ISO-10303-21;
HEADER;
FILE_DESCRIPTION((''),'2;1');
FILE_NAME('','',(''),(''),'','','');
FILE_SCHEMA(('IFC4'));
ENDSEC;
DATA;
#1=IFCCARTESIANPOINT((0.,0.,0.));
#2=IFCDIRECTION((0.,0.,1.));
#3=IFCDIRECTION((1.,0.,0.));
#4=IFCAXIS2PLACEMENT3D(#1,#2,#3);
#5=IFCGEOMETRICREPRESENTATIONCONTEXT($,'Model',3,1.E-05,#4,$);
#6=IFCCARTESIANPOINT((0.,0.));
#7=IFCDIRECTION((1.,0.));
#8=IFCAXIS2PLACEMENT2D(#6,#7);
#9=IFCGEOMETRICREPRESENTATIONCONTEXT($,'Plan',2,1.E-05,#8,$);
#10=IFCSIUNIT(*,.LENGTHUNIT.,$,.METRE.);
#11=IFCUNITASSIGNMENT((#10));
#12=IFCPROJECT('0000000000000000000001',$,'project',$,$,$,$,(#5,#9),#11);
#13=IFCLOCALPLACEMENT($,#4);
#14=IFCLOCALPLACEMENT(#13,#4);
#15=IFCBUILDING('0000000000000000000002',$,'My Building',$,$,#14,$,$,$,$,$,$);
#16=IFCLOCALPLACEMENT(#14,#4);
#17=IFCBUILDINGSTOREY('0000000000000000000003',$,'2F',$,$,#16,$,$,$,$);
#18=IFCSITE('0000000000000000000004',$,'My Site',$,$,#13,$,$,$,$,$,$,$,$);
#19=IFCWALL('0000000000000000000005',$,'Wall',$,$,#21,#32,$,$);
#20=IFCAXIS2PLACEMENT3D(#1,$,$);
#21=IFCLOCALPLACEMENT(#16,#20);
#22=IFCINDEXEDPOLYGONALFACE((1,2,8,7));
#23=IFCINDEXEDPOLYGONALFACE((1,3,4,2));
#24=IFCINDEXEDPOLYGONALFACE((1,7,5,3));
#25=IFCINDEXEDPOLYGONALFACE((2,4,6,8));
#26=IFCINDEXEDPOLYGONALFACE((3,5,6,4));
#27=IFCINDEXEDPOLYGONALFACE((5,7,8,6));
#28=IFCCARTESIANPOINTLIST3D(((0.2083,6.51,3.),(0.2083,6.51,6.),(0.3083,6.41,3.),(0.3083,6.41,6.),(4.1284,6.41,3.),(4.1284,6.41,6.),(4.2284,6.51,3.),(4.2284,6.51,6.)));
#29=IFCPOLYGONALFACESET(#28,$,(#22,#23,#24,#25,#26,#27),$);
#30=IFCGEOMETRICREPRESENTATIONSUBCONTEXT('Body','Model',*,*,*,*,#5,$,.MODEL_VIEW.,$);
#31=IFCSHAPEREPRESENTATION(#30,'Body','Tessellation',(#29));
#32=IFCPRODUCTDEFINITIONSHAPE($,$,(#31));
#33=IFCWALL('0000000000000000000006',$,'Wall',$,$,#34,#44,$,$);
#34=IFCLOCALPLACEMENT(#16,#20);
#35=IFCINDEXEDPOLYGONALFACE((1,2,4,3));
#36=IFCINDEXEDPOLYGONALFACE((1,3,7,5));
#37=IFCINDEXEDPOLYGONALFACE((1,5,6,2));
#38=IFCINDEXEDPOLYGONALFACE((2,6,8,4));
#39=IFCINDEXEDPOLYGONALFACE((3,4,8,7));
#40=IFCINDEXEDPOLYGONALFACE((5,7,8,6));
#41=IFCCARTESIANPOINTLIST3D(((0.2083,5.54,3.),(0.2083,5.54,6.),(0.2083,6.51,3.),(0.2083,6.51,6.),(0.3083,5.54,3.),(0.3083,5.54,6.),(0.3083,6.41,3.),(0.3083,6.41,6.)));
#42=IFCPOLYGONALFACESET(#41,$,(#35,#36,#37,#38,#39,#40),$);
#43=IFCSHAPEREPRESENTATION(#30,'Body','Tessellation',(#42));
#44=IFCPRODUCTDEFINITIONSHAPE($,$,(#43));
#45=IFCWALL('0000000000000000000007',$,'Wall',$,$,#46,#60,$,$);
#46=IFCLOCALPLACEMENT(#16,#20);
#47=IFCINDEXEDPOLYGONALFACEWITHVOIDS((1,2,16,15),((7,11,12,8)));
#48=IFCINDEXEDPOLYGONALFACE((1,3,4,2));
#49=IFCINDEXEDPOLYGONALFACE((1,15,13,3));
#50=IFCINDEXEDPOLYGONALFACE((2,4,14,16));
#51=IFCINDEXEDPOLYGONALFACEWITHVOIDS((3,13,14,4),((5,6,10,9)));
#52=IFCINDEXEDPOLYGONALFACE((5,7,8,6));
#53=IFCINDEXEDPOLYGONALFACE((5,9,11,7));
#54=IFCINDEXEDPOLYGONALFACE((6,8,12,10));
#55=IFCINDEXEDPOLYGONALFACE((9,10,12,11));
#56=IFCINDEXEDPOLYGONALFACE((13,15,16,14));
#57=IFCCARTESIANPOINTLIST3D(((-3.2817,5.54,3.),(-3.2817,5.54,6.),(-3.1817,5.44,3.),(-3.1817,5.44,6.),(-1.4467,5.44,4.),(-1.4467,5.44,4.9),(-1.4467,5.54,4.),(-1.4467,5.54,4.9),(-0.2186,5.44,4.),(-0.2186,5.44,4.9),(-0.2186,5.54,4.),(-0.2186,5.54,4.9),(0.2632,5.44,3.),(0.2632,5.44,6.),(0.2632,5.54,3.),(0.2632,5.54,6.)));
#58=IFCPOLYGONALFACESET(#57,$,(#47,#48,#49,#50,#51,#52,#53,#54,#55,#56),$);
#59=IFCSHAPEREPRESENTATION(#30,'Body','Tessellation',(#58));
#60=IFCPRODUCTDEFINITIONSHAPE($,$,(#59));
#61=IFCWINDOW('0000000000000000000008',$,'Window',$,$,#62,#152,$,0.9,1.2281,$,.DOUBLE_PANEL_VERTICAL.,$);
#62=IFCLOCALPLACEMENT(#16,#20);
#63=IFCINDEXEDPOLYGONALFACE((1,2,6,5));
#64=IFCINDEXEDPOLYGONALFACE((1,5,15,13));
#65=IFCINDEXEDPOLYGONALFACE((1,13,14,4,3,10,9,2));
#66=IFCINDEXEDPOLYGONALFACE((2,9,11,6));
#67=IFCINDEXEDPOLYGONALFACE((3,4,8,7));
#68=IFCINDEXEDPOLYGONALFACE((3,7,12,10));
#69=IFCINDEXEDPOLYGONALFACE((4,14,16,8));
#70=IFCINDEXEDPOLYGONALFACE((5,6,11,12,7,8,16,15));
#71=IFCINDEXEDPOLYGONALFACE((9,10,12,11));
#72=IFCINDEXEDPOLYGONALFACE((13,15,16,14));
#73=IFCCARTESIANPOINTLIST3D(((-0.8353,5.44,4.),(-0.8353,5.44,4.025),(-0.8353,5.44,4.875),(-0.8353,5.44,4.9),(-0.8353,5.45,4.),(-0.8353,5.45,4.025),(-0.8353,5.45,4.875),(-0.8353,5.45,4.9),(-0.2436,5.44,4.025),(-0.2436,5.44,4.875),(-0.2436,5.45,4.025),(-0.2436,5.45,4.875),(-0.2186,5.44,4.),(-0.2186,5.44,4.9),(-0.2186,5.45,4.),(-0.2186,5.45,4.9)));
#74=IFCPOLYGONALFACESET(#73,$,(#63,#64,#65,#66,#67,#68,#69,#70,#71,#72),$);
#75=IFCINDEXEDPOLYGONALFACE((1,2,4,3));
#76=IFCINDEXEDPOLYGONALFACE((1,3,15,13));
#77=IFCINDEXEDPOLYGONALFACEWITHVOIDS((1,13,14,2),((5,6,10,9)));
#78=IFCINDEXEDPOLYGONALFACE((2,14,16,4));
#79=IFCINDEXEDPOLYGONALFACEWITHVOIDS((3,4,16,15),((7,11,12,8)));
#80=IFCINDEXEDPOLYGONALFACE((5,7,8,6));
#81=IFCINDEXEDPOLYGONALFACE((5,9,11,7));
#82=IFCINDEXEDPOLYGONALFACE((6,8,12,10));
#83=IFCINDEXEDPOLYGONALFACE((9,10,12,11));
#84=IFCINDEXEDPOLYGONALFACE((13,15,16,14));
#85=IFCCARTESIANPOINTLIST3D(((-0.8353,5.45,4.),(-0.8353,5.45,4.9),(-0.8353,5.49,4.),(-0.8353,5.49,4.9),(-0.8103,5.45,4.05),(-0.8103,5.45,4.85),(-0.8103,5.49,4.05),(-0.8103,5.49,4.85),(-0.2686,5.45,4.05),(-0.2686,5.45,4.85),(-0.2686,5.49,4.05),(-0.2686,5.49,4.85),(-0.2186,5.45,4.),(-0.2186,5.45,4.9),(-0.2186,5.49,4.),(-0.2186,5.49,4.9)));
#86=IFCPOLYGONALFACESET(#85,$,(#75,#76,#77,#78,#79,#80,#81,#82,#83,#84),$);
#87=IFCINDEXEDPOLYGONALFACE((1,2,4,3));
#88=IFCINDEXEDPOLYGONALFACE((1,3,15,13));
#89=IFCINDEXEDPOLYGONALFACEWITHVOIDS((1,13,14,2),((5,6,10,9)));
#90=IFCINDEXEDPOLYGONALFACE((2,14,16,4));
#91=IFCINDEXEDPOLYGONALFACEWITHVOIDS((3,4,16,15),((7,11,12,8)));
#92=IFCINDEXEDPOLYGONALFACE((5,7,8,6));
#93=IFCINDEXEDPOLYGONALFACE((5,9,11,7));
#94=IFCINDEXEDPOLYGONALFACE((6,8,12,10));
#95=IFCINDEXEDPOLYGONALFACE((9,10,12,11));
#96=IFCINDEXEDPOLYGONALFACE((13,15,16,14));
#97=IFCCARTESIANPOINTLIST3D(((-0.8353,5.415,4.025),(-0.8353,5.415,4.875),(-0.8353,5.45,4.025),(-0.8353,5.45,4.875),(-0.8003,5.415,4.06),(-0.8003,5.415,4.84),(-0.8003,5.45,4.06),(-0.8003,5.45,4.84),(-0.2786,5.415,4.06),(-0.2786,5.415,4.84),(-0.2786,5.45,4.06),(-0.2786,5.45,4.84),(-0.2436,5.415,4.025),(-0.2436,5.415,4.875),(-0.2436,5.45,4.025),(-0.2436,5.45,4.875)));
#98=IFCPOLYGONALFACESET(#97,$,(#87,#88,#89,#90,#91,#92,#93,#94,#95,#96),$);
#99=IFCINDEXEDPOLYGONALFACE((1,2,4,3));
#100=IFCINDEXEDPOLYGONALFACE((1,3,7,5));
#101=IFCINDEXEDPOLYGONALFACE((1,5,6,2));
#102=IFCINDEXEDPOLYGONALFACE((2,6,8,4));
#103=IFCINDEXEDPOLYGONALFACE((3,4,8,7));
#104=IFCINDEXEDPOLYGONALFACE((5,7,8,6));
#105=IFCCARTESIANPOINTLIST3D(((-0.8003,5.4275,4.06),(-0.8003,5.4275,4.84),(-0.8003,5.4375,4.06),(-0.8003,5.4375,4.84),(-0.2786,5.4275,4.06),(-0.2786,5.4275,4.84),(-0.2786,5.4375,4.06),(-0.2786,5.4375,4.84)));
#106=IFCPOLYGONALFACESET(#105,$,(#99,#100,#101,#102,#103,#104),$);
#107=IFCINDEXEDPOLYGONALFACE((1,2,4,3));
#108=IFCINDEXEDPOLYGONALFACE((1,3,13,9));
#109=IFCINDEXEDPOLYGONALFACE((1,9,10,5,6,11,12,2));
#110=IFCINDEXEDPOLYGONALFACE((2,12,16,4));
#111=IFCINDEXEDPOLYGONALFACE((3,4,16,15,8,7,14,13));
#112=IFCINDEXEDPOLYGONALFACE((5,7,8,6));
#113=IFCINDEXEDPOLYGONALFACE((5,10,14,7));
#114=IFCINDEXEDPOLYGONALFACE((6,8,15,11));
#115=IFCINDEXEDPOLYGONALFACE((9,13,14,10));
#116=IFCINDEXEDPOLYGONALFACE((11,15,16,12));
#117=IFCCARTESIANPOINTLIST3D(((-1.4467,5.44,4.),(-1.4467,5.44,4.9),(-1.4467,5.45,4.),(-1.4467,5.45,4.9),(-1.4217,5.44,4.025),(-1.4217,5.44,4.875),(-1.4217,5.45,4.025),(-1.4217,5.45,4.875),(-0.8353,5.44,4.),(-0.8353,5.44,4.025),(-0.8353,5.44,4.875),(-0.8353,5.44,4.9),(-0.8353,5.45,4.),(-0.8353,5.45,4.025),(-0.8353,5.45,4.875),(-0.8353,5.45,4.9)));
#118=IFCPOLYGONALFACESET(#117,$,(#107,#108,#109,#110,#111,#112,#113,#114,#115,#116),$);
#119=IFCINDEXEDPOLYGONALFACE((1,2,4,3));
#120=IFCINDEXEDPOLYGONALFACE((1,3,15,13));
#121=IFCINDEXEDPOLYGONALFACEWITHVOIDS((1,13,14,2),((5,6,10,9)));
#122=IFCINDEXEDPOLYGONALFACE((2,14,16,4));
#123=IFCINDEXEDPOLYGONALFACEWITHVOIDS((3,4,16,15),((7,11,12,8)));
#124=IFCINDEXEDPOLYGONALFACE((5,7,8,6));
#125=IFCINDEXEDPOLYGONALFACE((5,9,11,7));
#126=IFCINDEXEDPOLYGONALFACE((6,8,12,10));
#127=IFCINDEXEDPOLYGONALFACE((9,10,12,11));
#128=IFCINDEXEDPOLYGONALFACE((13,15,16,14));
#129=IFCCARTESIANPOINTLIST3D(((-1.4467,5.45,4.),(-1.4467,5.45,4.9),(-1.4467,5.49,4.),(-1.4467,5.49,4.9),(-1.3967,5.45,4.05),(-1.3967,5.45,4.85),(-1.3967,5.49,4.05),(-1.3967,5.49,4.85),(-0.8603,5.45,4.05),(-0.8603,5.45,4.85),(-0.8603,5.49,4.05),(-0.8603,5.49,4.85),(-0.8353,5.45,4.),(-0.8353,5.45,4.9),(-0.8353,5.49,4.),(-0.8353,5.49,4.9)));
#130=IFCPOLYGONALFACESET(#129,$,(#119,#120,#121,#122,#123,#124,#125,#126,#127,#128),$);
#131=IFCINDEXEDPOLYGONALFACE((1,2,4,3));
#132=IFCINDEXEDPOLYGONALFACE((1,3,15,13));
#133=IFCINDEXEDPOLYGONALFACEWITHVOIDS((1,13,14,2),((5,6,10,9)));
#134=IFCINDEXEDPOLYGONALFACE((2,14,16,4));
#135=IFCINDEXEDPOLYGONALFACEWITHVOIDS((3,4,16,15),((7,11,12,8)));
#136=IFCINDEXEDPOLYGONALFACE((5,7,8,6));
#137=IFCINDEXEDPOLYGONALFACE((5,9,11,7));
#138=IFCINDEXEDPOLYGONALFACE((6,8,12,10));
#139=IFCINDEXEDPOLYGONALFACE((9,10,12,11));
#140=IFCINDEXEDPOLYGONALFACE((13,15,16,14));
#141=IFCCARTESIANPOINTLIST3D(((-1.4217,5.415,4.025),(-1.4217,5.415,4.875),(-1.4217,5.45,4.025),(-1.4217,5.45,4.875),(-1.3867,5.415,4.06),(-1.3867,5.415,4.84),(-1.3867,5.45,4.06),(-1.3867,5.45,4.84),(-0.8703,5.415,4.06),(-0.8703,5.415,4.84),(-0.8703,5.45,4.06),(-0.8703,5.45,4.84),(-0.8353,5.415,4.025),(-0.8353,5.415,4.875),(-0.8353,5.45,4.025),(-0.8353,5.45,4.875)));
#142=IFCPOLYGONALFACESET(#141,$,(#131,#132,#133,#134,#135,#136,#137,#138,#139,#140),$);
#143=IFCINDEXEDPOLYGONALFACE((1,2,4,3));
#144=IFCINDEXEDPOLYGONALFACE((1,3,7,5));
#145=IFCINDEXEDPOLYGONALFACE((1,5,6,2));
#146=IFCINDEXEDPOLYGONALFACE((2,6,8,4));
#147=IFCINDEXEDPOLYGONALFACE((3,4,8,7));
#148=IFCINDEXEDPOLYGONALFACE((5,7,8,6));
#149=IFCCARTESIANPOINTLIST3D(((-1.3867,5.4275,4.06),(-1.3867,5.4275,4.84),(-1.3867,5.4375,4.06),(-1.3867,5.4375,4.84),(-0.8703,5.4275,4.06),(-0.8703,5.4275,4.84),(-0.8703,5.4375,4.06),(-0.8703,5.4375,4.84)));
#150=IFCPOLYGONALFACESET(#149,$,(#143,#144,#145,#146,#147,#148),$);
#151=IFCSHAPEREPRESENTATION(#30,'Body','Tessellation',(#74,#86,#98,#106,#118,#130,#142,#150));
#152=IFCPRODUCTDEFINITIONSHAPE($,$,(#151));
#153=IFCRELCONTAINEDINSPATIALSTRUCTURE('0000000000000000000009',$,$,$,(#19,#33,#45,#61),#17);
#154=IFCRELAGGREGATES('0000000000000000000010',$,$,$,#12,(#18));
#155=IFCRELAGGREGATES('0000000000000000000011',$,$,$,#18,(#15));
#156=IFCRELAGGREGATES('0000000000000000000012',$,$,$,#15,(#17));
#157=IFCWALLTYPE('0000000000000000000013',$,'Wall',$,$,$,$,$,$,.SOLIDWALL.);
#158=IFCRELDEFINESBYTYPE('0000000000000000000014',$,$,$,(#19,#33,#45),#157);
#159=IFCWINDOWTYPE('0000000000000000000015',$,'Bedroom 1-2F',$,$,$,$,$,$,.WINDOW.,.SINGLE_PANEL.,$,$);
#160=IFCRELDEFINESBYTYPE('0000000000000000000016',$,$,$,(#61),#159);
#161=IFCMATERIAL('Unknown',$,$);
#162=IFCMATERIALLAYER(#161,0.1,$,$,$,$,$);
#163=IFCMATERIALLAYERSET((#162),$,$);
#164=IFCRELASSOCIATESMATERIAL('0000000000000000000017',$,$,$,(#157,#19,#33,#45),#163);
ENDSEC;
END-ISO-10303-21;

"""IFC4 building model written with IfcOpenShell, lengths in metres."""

from ifc_helpers import new_model, entity, si_unit, frame, origin_with_axes, origin_2d_with_axis, place, context, subcontext, project, spatial, line, indexed_curve, outline, extrude, shape, source, transform, mapped, material, layer, layer_set, layer_usage, type_object, type_shapes, element, fill, save


model = new_model("IFC4")

# Units and contexts
model_context = context("Model", 3, precision=1e-05, world=origin_with_axes())
plan_context = context("Plan", 2, precision=1e-05, world=origin_2d_with_axis())
body_context_1 = subcontext(model_context, "Body", "Model", "MODEL_VIEW")
body_context_2 = subcontext(plan_context, "Body", "Plan", "PLAN_VIEW")
ifc_project = project(units=[si_unit("LENGTHUNIT", "METRE")], contexts=[model_context, plan_context])

# Site, building, storey
site_placement = place(None, origin_with_axes())
site = spatial("IfcSite", under=ifc_project, at=site_placement, Name="My Site")
building_placement = place(site_placement, origin_with_axes())
building = spatial("IfcBuilding", under=site, at=building_placement, Name="My Building")
storey_placement = place(building_placement, origin_with_axes())
storey = spatial("IfcBuildingStorey", under=building, at=storey_placement, Name="2F")

# Walls
ifc_material = material(Name="Unknown")
ifc_layer = layer(ifc_material, 0.1)
ifc_layer_set = layer_set([ifc_layer])
ifc_layer_usage_1 = layer_usage(ifc_layer_set, "AXIS2", "POSITIVE", 0.0)
wall_type = type_object("IfcWallType", Name="Wall", PredefinedType="SOLIDWALL", material=ifc_layer_set)
wall_1_placement = place(storey_placement, frame((4.2284, 6.51, 3.0), z_axis=(0.0, 0.0, 1.0), x_axis=(-1.0, 0.0, 0.0)))
element("IfcWall", 1, at=wall_1_placement, inside=storey, type_object=wall_type, material=ifc_layer_usage_1, Name="Wall", context=body_context_1, shape_type="SweptSolid", body=[
    extrude(outline(indexed_curve([(0.0, 0.0), (0.1, 0.1), (3.92, 0.1), (4.02, 0.0)], segments=[line(1, 2, 3, 4, 1)])), origin_with_axes(), (0.0, 0.0, 1.0), 3.0),
])
ifc_layer_usage_2 = layer_usage(ifc_layer_set, "AXIS2", "POSITIVE", 0.0)
wall_2_placement = place(storey_placement, frame((0.2083, 6.51, 3.0), z_axis=(0.0, 0.0, 1.0), x_axis=(0.0, -1.0, 0.0)))
element("IfcWall", 2, at=wall_2_placement, inside=storey, type_object=wall_type, material=ifc_layer_usage_2, Name="Wall", context=body_context_1, shape_type="SweptSolid", body=[
    extrude(outline(indexed_curve([(0.0, 0.0), (0.1, 0.1), (0.97, 0.1), (0.97, 0.0)], segments=[line(1, 2, 3, 4, 1)])), origin_with_axes(), (0.0, 0.0, 1.0), 3.0),
])

# Wall, opening, window
ifc_layer_usage_3 = layer_usage(ifc_layer_set, "AXIS2", "POSITIVE", 0.0)
wall_3_placement = place(storey_placement, frame((0.2632, 5.54, 3.0), z_axis=(0.0, 0.0, 1.0), x_axis=(-1.0, 0.0, 0.0)))
wall_3 = element("IfcWall", 3, at=wall_3_placement, inside=storey, type_object=wall_type, material=ifc_layer_usage_3, Name="Wall", context=body_context_1, shape_type="SweptSolid", body=[
    extrude(outline(indexed_curve([(0.0, 0.0), (0.0, 0.1), (3.4448, 0.1), (3.5448, 0.0)], segments=[line(1, 2, 3, 4, 1)])), origin_with_axes(), (0.0, 0.0, 1.0), 3.0),
])
shared_shape_1 = source(origin_with_axes(), body_context_1, "Body", "SweptSolid", [
    extrude(outline(indexed_curve([(0.0, 0.0), (1.2281, 0.0), (1.2281, 0.9), (0.0, 0.9)], segments=[line(1, 2, 3, 4, 1)])), frame((0.0, -0.6, 0.0), z_axis=(0.0, -1.0, 0.0), x_axis=(1.0, 0.0, 0.0)), (0.0, 0.0, -1.0), 1.2),
])
opening_1_placement = place(wall_3_placement, frame((0.4818, 0.0, 1.0), z_axis=(0.0, 0.0, 1.0), x_axis=(1.0, 0.0, 0.0)))
opening_1 = element("IfcOpeningElement", 4, at=opening_1_placement, cuts=wall_3, PredefinedType="OPENING", context=body_context_1, shape_type="MappedRepresentation", body=[
    mapped(shared_shape_1, transform((0.0, 0.0, 0.0), x_axis=(1.0, 0.0, 0.0), y_axis=(0.0, 1.0, 0.0), z_axis=(0.0, 0.0, 1.0), scale=1.0)),
])
window_type_1 = type_object("IfcWindowType", Name="Bedroom 1-2F", PartitioningType="SINGLE_PANEL", PredefinedType="WINDOW")
shared_shape_2 = source(origin_with_axes(), body_context_1, "Body", "SweptSolid", [
    extrude(outline(indexed_curve([(0.6167, 0.0), (0.0, 0.0), (0.0, 0.9), (0.6167, 0.9), (0.6167, 0.875), (0.025, 0.875), (0.025, 0.025), (0.6167, 0.025)], segments=[line(1, 2, 3, 4, 5, 6, 7, 8, 1)])), frame((0.0, 0.09, 0.0), z_axis=(0.0, -1.0, 0.0), x_axis=(1.0, 0.0, 0.0)), (0.0, 0.0, -1.0), 0.01),
    extrude(outline(indexed_curve([(0.0, 0.0), (0.6167, 0.0), (0.6167, 0.9), (0.0, 0.9)], segments=[line(1, 2, 3, 4, 1)]), holes=[indexed_curve([(0.05, 0.05), (0.5917, 0.05), (0.5917, 0.85), (0.05, 0.85)], segments=[line(1, 2, 3, 4, 1)])]), frame((0.0, 0.05, 0.0), z_axis=(0.0, -1.0, 0.0), x_axis=(1.0, 0.0, 0.0)), (0.0, 0.0, -1.0), 0.04),
    extrude(outline(indexed_curve([(0.0, 0.0), (0.5917, 0.0), (0.5917, 0.85), (0.0, 0.85)], segments=[line(1, 2, 3, 4, 1)]), holes=[indexed_curve([(0.035, 0.035), (0.5567, 0.035), (0.5567, 0.815), (0.035, 0.815)], segments=[line(1, 2, 3, 4, 1)])]), frame((0.025, 0.09, 0.025), z_axis=(0.0, -1.0, 0.0), x_axis=(1.0, 0.0, 0.0)), (0.0, 0.0, -1.0), 0.035),
    extrude(outline(indexed_curve([(0.035, 0.035), (0.5567, 0.035), (0.5567, 0.815), (0.035, 0.815)], segments=[line(1, 2, 3, 4, 1)])), frame((0.025, 0.1025, 0.025), z_axis=(0.0, -1.0, 0.0), x_axis=(1.0, 0.0, 0.0)), (0.0, 0.0, -1.0), 0.01),
    extrude(outline(indexed_curve([(0.0, 0.9), (0.6114, 0.9), (0.6114, 0.0), (0.0, 0.0), (0.0, 0.025), (0.5864, 0.025), (0.5864, 0.875), (0.0, 0.875)], segments=[line(1, 2, 3, 4, 5, 6, 7, 8, 1)])), frame((0.6167, 0.09, 0.0), z_axis=(0.0, -1.0, 0.0), x_axis=(1.0, 0.0, 0.0)), (0.0, 0.0, -1.0), 0.01),
    extrude(outline(indexed_curve([(0.0, 0.0), (0.6114, 0.0), (0.6114, 0.9), (0.0, 0.9)], segments=[line(1, 2, 3, 4, 1)]), holes=[indexed_curve([(0.025, 0.05), (0.5614, 0.05), (0.5614, 0.85), (0.025, 0.85)], segments=[line(1, 2, 3, 4, 1)])]), frame((0.6167, 0.05, 0.0), z_axis=(0.0, -1.0, 0.0), x_axis=(1.0, 0.0, 0.0)), (0.0, 0.0, -1.0), 0.04),
    extrude(outline(indexed_curve([(0.0, 0.0), (0.5864, 0.0), (0.5864, 0.85), (0.0, 0.85)], segments=[line(1, 2, 3, 4, 1)]), holes=[indexed_curve([(0.035, 0.035), (0.5514, 0.035), (0.5514, 0.815), (0.035, 0.815)], segments=[line(1, 2, 3, 4, 1)])]), frame((0.6167, 0.09, 0.025), z_axis=(0.0, -1.0, 0.0), x_axis=(1.0, 0.0, 0.0)), (0.0, 0.0, -1.0), 0.035),
    extrude(outline(indexed_curve([(0.035, 0.035), (0.5514, 0.035), (0.5514, 0.815), (0.035, 0.815)], segments=[line(1, 2, 3, 4, 1)])), frame((0.6167, 0.1025, 0.025), z_axis=(0.0, -1.0, 0.0), x_axis=(1.0, 0.0, 0.0)), (0.0, 0.0, -1.0), 0.01),
])
shared_shape_3 = source(origin_with_axes(), body_context_2, "Body", "Curve2D", [
    entity("IfcIndexedPolyCurve", entity("IfcCartesianPointList2D", [[0.05, 0.05], [0.5917, 0.05]])),
    entity("IfcIndexedPolyCurve", entity("IfcCartesianPointList2D", [[0.0, 0.1], [0.025, 0.1], [0.025, 0.09], [0.05, 0.09], [0.05, 0.05], [0.0, 0.05]]), [entity("IfcLineIndex", [1, 2, 3, 4, 5, 6, 1])]),
    entity("IfcIndexedPolyCurve", entity("IfcCartesianPointList2D", [[0.6167, 0.1], [0.6167, 0.1], [0.6167, 0.09], [0.5917, 0.09], [0.5917, 0.05], [0.6167, 0.05]])),
    entity("IfcIndexedPolyCurve", entity("IfcCartesianPointList2D", [[0.025, 0.09], [0.06, 0.09], [0.06, 0.125], [0.025, 0.125]]), [entity("IfcLineIndex", [1, 2, 3, 4, 1])]),
    entity("IfcIndexedPolyCurve", entity("IfcCartesianPointList2D", [[0.6167, 0.09], [0.5817, 0.09], [0.5817, 0.125], [0.6167, 0.125]]), [entity("IfcLineIndex", [1, 2, 3, 4, 1])]),
    entity("IfcIndexedPolyCurve", entity("IfcCartesianPointList2D", [[0.06, 0.09], [0.5817, 0.09]])),
    entity("IfcIndexedPolyCurve", entity("IfcCartesianPointList2D", [[0.06, 0.125], [0.5817, 0.125]])),
    entity("IfcIndexedPolyCurve", entity("IfcCartesianPointList2D", [[0.06, 0.1075], [0.5817, 0.1075]])),
    entity("IfcIndexedPolyCurve", entity("IfcCartesianPointList2D", [[0.6417, 0.05], [1.1781, 0.05]])),
    entity("IfcIndexedPolyCurve", entity("IfcCartesianPointList2D", [[0.6167, 0.1], [0.6167, 0.1], [0.6167, 0.09], [0.6417, 0.09], [0.6417, 0.05], [0.6167, 0.05]])),
    entity("IfcIndexedPolyCurve", entity("IfcCartesianPointList2D", [[1.2281, 0.1], [1.2031, 0.1], [1.2031, 0.09], [1.1781, 0.09], [1.1781, 0.05], [1.2281, 0.05]]), [entity("IfcLineIndex", [1, 2, 3, 4, 5, 6, 1])]),
    entity("IfcIndexedPolyCurve", entity("IfcCartesianPointList2D", [[0.6167, 0.09], [0.6517, 0.09], [0.6517, 0.125], [0.6167, 0.125]]), [entity("IfcLineIndex", [1, 2, 3, 4, 1])]),
    entity("IfcIndexedPolyCurve", entity("IfcCartesianPointList2D", [[1.2031, 0.09], [1.1681, 0.09], [1.1681, 0.125], [1.2031, 0.125]]), [entity("IfcLineIndex", [1, 2, 3, 4, 1])]),
    entity("IfcIndexedPolyCurve", entity("IfcCartesianPointList2D", [[0.6517, 0.09], [1.1681, 0.09]])),
    entity("IfcIndexedPolyCurve", entity("IfcCartesianPointList2D", [[0.6517, 0.125], [1.1681, 0.125]])),
    entity("IfcIndexedPolyCurve", entity("IfcCartesianPointList2D", [[0.6517, 0.1075], [1.1681, 0.1075]])),
])
type_shapes(window_type_1, [shared_shape_2, shared_shape_3])
window_1_placement = place(opening_1_placement, origin_with_axes())
window_1 = element("IfcWindow", 5, at=window_1_placement, inside=storey, type_object=window_type_1, Name="Window", OverallHeight=0.9, OverallWidth=1.2281, PartitioningType="DOUBLE_PANEL_VERTICAL", shapes=[
    shape(body_context_1, "Body", "MappedRepresentation", [mapped(shared_shape_2, transform((0.0, 0.0, 0.0), x_axis=(1.0, 0.0, 0.0), y_axis=(0.0, 1.0, 0.0), z_axis=(0.0, 0.0, 1.0), scale=1.0))]),
    shape(body_context_2, "Body", "MappedRepresentation", [mapped(shared_shape_3, transform((0.0, 0.0, 0.0), x_axis=(1.0, 0.0, 0.0), y_axis=(0.0, 1.0, 0.0), z_axis=(0.0, 0.0, 1.0), scale=1.0))]),
])
fill(opening_1, window_1)

save(model, "model.ifc")
